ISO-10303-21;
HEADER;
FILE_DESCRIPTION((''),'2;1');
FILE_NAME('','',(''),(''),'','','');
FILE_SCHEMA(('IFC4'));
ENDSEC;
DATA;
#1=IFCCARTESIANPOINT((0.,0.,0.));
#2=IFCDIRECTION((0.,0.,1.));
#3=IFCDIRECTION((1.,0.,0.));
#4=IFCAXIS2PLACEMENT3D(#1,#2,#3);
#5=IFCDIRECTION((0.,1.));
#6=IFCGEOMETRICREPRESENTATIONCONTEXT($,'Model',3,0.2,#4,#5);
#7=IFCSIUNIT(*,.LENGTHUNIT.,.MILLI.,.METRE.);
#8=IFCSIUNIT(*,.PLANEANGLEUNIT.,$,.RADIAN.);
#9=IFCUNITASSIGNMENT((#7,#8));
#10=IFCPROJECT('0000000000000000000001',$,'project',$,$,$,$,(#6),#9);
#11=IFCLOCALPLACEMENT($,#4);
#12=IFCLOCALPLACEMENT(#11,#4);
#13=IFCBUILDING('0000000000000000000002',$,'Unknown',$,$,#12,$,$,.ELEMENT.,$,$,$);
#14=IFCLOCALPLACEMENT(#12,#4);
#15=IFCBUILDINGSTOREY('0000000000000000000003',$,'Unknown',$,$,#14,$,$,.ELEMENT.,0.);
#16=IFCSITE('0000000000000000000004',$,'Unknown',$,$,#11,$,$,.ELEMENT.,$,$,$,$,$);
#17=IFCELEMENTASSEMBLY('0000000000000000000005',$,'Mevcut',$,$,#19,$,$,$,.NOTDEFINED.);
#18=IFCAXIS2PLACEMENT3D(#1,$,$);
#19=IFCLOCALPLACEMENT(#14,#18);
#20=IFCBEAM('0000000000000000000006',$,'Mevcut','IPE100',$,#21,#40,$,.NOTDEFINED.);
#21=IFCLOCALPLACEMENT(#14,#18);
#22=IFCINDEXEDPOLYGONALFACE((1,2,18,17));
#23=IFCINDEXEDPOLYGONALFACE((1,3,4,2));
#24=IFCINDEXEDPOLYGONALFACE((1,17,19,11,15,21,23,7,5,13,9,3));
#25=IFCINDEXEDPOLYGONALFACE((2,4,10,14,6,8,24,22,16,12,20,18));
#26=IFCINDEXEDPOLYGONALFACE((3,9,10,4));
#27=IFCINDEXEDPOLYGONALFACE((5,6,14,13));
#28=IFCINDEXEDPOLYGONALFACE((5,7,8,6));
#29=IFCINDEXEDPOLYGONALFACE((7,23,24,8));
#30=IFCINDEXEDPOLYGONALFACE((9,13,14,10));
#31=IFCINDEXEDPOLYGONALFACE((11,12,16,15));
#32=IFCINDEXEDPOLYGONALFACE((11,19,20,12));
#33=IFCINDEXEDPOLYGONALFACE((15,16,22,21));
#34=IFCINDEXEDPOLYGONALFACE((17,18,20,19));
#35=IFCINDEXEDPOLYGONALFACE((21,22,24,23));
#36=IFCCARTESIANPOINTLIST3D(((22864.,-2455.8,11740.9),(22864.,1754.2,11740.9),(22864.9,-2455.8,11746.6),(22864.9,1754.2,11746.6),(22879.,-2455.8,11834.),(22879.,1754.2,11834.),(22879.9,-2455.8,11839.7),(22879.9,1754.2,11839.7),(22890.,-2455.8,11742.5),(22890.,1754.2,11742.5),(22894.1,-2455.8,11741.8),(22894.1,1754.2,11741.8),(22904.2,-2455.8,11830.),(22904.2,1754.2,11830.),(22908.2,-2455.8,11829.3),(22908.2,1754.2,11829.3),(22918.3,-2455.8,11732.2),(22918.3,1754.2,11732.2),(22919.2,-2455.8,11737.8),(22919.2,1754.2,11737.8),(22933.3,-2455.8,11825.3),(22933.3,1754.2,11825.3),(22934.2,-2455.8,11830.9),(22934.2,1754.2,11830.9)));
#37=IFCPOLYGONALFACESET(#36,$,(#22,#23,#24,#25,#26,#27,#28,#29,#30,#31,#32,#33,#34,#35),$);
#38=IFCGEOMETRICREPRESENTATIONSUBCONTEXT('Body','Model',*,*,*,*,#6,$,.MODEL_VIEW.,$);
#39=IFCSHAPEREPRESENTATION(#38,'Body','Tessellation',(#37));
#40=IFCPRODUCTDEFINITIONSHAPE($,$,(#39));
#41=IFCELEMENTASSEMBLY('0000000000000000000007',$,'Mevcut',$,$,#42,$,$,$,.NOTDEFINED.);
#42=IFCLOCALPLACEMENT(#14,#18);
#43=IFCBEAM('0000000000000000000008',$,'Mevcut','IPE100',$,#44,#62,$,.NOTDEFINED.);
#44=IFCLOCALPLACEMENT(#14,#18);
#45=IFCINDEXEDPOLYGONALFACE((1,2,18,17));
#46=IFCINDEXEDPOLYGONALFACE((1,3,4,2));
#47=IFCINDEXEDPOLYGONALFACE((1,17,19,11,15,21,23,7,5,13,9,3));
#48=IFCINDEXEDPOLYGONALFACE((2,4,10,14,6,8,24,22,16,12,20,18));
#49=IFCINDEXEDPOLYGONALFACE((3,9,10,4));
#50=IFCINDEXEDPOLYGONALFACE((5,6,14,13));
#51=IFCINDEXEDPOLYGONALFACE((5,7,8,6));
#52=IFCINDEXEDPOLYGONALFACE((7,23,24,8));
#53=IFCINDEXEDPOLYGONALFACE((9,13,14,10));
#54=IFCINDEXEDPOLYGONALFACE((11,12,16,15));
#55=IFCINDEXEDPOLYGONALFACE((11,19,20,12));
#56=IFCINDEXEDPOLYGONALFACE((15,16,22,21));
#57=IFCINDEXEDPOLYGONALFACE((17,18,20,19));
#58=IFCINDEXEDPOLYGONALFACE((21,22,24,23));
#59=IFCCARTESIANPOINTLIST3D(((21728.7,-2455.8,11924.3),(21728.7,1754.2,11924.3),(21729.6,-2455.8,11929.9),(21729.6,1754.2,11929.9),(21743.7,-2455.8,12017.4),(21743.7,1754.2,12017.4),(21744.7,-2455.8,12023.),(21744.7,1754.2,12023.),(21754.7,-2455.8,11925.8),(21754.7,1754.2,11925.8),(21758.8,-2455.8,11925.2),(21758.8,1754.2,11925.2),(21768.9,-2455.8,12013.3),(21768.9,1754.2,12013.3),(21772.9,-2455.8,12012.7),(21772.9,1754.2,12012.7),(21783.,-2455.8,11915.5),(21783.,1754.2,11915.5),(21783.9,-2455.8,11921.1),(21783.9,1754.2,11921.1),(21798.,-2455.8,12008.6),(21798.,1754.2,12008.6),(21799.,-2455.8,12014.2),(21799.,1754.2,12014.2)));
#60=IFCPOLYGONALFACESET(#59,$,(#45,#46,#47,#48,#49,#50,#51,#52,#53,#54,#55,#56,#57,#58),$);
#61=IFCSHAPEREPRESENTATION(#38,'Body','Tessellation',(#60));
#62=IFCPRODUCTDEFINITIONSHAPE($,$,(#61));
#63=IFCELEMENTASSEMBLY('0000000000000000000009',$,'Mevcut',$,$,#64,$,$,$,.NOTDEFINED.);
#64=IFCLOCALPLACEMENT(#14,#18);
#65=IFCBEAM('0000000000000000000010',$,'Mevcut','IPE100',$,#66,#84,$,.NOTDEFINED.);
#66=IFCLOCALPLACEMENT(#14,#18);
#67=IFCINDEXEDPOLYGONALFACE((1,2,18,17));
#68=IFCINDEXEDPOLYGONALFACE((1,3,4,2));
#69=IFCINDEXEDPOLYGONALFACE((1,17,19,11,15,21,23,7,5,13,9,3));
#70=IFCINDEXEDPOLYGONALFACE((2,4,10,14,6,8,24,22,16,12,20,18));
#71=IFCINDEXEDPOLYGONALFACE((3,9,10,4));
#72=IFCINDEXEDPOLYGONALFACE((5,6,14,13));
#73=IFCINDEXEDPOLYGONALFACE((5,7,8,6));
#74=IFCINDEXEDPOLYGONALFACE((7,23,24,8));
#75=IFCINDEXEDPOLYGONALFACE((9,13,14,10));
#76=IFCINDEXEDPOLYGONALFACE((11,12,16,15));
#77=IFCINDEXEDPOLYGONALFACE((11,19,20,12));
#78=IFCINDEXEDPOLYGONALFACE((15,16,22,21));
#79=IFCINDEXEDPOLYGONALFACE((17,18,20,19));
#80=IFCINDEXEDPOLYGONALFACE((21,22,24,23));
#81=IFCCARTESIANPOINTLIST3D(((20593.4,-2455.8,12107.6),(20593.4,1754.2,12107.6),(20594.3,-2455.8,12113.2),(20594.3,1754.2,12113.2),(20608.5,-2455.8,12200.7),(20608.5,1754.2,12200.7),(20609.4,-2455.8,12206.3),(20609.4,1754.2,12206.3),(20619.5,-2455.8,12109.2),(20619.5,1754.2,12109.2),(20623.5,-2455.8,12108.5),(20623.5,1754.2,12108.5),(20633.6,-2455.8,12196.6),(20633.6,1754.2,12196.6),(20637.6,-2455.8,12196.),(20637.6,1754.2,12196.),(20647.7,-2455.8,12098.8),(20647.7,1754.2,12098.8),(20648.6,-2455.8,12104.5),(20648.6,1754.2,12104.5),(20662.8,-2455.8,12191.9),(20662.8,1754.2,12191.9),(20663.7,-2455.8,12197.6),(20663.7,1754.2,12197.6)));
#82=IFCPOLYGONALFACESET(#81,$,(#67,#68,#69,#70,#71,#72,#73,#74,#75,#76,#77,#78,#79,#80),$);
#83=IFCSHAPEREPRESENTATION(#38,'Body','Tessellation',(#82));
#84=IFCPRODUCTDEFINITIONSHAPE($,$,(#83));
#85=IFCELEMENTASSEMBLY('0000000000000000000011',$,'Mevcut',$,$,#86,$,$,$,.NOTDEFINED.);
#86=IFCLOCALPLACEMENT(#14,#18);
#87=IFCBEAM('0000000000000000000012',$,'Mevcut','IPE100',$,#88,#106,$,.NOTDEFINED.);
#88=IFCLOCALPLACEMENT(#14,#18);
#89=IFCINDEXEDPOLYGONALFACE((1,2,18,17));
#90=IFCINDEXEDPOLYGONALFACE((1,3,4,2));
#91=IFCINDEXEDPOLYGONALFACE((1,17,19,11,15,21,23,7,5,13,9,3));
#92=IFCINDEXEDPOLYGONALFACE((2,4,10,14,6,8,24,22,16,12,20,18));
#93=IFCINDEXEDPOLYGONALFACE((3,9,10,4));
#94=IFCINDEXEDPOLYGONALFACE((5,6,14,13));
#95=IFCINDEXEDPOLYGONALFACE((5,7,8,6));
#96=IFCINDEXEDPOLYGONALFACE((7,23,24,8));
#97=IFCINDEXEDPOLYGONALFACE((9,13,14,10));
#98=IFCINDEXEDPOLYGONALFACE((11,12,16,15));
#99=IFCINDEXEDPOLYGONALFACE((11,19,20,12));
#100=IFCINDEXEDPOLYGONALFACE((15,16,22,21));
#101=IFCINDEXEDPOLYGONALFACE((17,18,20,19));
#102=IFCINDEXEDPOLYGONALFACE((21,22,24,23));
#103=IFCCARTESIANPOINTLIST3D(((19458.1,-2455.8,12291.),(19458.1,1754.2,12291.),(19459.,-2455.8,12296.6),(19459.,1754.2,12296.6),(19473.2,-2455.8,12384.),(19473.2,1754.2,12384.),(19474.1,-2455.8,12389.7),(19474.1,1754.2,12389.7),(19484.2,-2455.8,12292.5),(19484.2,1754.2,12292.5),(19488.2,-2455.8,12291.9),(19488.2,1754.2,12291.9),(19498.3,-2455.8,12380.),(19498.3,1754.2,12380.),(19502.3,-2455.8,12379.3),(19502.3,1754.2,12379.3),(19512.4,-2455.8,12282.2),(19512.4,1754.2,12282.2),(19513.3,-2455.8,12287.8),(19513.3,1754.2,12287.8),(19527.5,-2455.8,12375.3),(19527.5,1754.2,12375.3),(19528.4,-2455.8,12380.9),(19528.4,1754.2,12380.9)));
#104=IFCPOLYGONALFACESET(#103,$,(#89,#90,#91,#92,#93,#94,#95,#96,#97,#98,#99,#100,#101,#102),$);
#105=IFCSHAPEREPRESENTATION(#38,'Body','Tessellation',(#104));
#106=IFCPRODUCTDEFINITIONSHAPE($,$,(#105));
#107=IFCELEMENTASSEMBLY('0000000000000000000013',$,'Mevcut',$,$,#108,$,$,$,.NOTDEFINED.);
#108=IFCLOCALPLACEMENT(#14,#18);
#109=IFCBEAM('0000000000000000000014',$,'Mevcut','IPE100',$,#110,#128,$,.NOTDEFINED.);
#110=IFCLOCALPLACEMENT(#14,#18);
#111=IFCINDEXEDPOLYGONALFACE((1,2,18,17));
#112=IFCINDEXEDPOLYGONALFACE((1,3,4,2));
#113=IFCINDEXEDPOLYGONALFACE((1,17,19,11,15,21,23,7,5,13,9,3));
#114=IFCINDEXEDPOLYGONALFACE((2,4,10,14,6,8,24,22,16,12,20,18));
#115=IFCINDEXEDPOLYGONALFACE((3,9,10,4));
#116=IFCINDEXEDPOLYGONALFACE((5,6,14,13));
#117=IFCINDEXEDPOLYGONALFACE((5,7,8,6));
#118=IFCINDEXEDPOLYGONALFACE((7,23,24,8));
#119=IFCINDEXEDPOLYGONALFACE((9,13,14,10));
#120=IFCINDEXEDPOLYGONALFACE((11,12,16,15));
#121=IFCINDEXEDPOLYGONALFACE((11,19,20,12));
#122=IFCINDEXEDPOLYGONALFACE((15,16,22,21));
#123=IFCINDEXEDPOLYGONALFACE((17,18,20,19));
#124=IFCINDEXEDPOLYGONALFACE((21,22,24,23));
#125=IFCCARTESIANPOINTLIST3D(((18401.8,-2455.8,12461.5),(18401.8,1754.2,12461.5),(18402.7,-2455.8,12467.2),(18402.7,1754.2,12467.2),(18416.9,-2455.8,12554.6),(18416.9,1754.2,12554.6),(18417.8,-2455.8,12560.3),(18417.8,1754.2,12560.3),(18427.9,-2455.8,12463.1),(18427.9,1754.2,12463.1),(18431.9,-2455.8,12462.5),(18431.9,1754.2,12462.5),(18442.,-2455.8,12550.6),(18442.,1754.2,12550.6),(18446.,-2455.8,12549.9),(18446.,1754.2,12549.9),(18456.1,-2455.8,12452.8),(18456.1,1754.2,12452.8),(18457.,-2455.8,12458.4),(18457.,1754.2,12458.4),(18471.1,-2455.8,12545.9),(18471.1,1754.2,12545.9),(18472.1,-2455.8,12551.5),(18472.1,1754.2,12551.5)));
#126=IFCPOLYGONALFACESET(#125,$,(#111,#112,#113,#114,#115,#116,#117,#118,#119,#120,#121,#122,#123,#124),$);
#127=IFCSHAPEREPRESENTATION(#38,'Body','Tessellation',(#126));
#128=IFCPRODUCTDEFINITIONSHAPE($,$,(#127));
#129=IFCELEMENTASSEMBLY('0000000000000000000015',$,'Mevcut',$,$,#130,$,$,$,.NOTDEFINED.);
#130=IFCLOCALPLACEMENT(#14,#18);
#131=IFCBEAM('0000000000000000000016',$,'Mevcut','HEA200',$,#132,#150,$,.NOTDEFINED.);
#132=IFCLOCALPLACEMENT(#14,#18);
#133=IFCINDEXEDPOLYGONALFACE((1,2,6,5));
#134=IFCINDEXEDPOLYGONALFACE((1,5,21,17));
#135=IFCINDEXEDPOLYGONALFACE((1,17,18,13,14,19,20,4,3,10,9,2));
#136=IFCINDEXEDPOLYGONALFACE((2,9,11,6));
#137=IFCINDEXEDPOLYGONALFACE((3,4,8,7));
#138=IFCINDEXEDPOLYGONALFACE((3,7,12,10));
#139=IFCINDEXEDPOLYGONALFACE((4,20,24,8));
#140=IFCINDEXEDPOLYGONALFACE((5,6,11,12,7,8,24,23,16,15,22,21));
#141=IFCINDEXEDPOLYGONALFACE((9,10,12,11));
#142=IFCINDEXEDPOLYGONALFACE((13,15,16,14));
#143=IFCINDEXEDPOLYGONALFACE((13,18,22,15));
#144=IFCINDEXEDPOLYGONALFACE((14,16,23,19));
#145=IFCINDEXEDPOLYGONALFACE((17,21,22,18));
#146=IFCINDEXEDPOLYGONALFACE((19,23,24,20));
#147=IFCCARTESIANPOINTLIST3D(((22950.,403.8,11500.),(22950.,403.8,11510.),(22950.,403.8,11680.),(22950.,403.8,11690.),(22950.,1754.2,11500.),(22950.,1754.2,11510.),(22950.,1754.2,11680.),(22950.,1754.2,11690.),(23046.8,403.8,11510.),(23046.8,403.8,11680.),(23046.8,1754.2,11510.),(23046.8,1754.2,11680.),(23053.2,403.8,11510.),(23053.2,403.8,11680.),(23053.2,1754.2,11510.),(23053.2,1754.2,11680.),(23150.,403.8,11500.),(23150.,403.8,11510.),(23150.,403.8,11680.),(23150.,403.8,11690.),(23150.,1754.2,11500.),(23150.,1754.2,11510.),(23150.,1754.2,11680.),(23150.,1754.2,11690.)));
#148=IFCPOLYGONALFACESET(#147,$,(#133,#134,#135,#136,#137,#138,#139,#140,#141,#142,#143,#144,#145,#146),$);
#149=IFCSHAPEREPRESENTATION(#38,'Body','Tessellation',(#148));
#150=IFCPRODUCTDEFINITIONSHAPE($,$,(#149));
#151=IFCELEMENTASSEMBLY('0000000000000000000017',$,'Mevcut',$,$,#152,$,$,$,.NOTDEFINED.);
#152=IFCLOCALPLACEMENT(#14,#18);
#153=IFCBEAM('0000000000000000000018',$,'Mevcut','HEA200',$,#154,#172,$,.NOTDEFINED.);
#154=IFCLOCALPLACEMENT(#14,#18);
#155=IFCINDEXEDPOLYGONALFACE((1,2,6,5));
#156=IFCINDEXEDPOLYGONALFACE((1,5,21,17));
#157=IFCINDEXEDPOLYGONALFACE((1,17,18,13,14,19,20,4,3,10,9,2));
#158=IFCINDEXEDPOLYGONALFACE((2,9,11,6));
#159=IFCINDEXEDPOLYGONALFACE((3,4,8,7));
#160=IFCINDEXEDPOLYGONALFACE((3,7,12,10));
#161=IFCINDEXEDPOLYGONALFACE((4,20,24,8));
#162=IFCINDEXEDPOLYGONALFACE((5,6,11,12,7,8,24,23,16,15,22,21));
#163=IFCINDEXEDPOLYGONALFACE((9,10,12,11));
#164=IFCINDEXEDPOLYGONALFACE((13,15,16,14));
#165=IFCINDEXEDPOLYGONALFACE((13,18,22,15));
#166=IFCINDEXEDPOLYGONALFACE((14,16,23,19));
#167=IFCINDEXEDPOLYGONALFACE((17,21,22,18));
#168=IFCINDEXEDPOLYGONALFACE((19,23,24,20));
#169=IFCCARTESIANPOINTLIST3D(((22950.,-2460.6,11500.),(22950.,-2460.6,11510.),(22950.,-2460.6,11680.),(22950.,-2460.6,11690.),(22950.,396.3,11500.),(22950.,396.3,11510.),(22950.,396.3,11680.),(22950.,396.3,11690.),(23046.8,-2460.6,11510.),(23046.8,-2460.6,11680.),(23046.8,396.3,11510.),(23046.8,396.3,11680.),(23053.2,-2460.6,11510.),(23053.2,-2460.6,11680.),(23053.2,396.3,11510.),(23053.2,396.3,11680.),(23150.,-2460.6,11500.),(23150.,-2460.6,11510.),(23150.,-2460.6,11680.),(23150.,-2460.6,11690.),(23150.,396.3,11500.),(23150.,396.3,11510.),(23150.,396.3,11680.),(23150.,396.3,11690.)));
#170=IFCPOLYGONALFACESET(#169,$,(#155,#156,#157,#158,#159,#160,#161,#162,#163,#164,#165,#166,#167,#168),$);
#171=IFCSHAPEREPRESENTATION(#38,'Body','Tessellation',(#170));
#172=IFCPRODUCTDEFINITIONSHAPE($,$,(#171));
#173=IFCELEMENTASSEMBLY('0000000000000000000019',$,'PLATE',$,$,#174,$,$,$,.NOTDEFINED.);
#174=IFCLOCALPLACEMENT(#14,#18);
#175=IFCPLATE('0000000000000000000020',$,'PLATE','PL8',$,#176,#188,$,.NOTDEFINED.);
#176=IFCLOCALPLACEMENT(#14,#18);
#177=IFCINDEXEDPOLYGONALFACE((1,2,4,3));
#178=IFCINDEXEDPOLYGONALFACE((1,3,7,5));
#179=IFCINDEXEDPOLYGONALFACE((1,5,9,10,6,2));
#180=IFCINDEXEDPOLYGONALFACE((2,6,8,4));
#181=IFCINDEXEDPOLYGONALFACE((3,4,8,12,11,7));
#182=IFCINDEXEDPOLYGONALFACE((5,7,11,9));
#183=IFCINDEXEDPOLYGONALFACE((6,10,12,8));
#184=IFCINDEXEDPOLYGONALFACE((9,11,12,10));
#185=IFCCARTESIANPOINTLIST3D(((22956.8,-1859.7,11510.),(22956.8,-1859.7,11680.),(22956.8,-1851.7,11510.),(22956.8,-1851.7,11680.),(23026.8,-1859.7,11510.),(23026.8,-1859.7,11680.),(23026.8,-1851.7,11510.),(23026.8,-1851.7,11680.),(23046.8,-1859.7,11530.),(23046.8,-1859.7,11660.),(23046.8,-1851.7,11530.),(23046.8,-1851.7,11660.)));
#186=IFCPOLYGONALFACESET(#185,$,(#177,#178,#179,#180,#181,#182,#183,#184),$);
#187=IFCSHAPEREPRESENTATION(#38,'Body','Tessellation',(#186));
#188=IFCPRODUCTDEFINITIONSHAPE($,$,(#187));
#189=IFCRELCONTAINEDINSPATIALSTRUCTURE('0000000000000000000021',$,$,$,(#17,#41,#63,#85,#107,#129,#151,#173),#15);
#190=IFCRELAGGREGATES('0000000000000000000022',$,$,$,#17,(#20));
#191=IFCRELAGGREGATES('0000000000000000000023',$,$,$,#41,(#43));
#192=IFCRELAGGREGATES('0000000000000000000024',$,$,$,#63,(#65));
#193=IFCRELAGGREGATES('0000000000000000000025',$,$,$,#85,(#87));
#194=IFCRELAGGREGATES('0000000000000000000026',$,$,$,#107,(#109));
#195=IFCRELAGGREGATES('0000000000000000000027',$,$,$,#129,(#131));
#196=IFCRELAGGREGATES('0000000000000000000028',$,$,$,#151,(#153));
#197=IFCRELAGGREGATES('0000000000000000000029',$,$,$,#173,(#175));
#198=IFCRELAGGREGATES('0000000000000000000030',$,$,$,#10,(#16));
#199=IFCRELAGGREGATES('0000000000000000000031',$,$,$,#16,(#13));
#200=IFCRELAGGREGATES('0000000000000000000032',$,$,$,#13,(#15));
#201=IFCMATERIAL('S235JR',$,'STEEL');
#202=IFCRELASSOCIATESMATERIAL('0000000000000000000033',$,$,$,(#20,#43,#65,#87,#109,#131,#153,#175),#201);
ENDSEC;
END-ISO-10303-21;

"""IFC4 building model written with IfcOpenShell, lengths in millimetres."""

from ifc_helpers import new_model, si_unit, direction, frame, origin_with_axes, place, context, subcontext, project, spatial, line, indexed_curve, outline, extrude, material, element, aggregate, save


model = new_model("IFC4")

# Units and contexts
model_context = context("Model", 3, precision=0.2, world=origin_with_axes(), true_north=direction((0.0, 1.0)))
body_context = subcontext(model_context, "Body", "Model", "MODEL_VIEW")
ifc_project = project(units=[si_unit("LENGTHUNIT", "METRE", prefix="MILLI"), si_unit("PLANEANGLEUNIT", "RADIAN")], contexts=[model_context])

# Site, building, storey
site_placement = place(None, origin_with_axes())
site = spatial("IfcSite", under=ifc_project, at=site_placement, Name="Unknown", CompositionType="ELEMENT")
building_placement = place(site_placement, origin_with_axes())
building = spatial("IfcBuilding", under=site, at=building_placement, Name="Unknown", CompositionType="ELEMENT")
storey_placement = place(building_placement, origin_with_axes())
storey = spatial("IfcBuildingStorey", under=building, at=storey_placement, Name="Unknown", CompositionType="ELEMENT", Elevation=0.0)

# Element assemblies, beams
assembly_1_placement = place(storey_placement, frame((22899.1, 1754.2, 11785.9), z_axis=(0.98722, 0.0, -0.159364), x_axis=(0.0, -1.0, 0.0)))
assembly_1 = element("IfcElementAssembly", 1, at=assembly_1_placement, inside=storey, Name="Mevcut", PredefinedType="NOTDEFINED")
ifc_material = material(Name="S235JR", Category="STEEL")
beam_1_placement = place(assembly_1_placement, origin_with_axes())
beam_1 = element("IfcBeam", 2, at=beam_1_placement, material=ifc_material, Name="Mevcut", Description="IPE100", PredefinedType="NOTDEFINED", context=body_context, shape_type="SolidModel", body=[
    extrude(outline(indexed_curve([(-27.5, -50.0), (27.5, -50.0), (27.5, -44.3), (2.0, -44.3), (2.0, 44.3), (27.5, 44.3), (27.5, 50.0), (-27.5, 50.0), (-27.5, 44.3), (-2.0, 44.3), (-2.0, -44.3), (-27.5, -44.3)], segments=[line(1, 2, 3, 4, 5, 6, 7, 8, 9, 10, 11, 12, 1)])), frame((0.0, 0.0, 0.0), z_axis=(-1.0, 0.0, 0.0), x_axis=(0.0, 0.0, 1.0)), (0.0, 0.0, -1.0), 4210.0),
])
aggregate(assembly_1, [beam_1])
assembly_2_placement = place(storey_placement, frame((21763.8, 1754.2, 11969.2), z_axis=(0.98721, 0.0, -0.159427), x_axis=(0.0, -1.0, 0.0)))
assembly_2 = element("IfcElementAssembly", 3, at=assembly_2_placement, inside=storey, Name="Mevcut", PredefinedType="NOTDEFINED")
beam_2_placement = place(assembly_2_placement, origin_with_axes())
beam_2 = element("IfcBeam", 4, at=beam_2_placement, material=ifc_material, Name="Mevcut", Description="IPE100", PredefinedType="NOTDEFINED", context=body_context, shape_type="SolidModel", body=[
    extrude(outline(indexed_curve([(-27.5, -50.0), (27.5, -50.0), (27.5, -44.3), (2.0, -44.3), (2.0, 44.3), (27.5, 44.3), (27.5, 50.0), (-27.5, 50.0), (-27.5, 44.3), (-2.0, 44.3), (-2.0, -44.3), (-27.5, -44.3)], segments=[line(1, 2, 3, 4, 5, 6, 7, 8, 9, 10, 11, 12, 1)])), frame((0.0, 0.0, 0.0), z_axis=(-1.0, 0.0, 0.0), x_axis=(0.0, 0.0, 1.0)), (0.0, 0.0, -1.0), 4210.0),
])
aggregate(assembly_2, [beam_2])
assembly_3_placement = place(storey_placement, frame((20628.5, 1754.2, 12152.6), z_axis=(0.98721, 0.0, -0.159427), x_axis=(0.0, -1.0, 0.0)))
assembly_3 = element("IfcElementAssembly", 5, at=assembly_3_placement, inside=storey, Name="Mevcut", PredefinedType="NOTDEFINED")
beam_3_placement = place(assembly_3_placement, origin_with_axes())
beam_3 = element("IfcBeam", 6, at=beam_3_placement, material=ifc_material, Name="Mevcut", Description="IPE100", PredefinedType="NOTDEFINED", context=body_context, shape_type="SolidModel", body=[
    extrude(outline(indexed_curve([(-27.5, -50.0), (27.5, -50.0), (27.5, -44.3), (2.0, -44.3), (2.0, 44.3), (27.5, 44.3), (27.5, 50.0), (-27.5, 50.0), (-27.5, 44.3), (-2.0, 44.3), (-2.0, -44.3), (-27.5, -44.3)], segments=[line(1, 2, 3, 4, 5, 6, 7, 8, 9, 10, 11, 12, 1)])), frame((0.0, 0.0, 0.0), z_axis=(-1.0, 0.0, 0.0), x_axis=(0.0, 0.0, 1.0)), (0.0, 0.0, -1.0), 4210.0),
])
aggregate(assembly_3, [beam_3])
assembly_4_placement = place(storey_placement, frame((19493.3, 1754.2, 12335.9), z_axis=(0.98721, 0.0, -0.159427), x_axis=(0.0, -1.0, 0.0)))
assembly_4 = element("IfcElementAssembly", 7, at=assembly_4_placement, inside=storey, Name="Mevcut", PredefinedType="NOTDEFINED")
beam_4_placement = place(assembly_4_placement, origin_with_axes())
beam_4 = element("IfcBeam", 8, at=beam_4_placement, material=ifc_material, Name="Mevcut", Description="IPE100", PredefinedType="NOTDEFINED", context=body_context, shape_type="SolidModel", body=[
    extrude(outline(indexed_curve([(-27.5, -50.0), (27.5, -50.0), (27.5, -44.3), (2.0, -44.3), (2.0, 44.3), (27.5, 44.3), (27.5, 50.0), (-27.5, 50.0), (-27.5, 44.3), (-2.0, 44.3), (-2.0, -44.3), (-27.5, -44.3)], segments=[line(1, 2, 3, 4, 5, 6, 7, 8, 9, 10, 11, 12, 1)])), frame((0.0, 0.0, 0.0), z_axis=(-1.0, 0.0, 0.0), x_axis=(0.0, 0.0, 1.0)), (0.0, 0.0, -1.0), 4210.0),
])
aggregate(assembly_4, [beam_4])
assembly_5_placement = place(storey_placement, frame((18436.9, 1754.2, 12506.5), z_axis=(0.98721, 0.0, -0.159427), x_axis=(0.0, -1.0, 0.0)))
assembly_5 = element("IfcElementAssembly", 9, at=assembly_5_placement, inside=storey, Name="Mevcut", PredefinedType="NOTDEFINED")
beam_5_placement = place(assembly_5_placement, origin_with_axes())
beam_5 = element("IfcBeam", 10, at=beam_5_placement, material=ifc_material, Name="Mevcut", Description="IPE100", PredefinedType="NOTDEFINED", context=body_context, shape_type="SolidModel", body=[
    extrude(outline(indexed_curve([(-27.5, -50.0), (27.5, -50.0), (27.5, -44.3), (2.0, -44.3), (2.0, 44.3), (27.5, 44.3), (27.5, 50.0), (-27.5, 50.0), (-27.5, 44.3), (-2.0, 44.3), (-2.0, -44.3), (-27.5, -44.3)], segments=[line(1, 2, 3, 4, 5, 6, 7, 8, 9, 10, 11, 12, 1)])), frame((0.0, 0.0, 0.0), z_axis=(-1.0, 0.0, 0.0), x_axis=(0.0, 0.0, 1.0)), (0.0, 0.0, -1.0), 4210.0),
])
aggregate(assembly_5, [beam_5])
assembly_6_placement = place(storey_placement, frame((23050.0, 1754.2, 11595.0), z_axis=(-1.0, 0.0, 0.0), x_axis=(0.0, -1.0, 0.0)))
assembly_6 = element("IfcElementAssembly", 11, at=assembly_6_placement, inside=storey, Name="Mevcut", PredefinedType="NOTDEFINED")
beam_6_placement = place(assembly_6_placement, origin_with_axes())
beam_6 = element("IfcBeam", 12, at=beam_6_placement, material=ifc_material, Name="Mevcut", Description="HEA200", PredefinedType="NOTDEFINED", context=body_context, shape_type="SolidModel", body=[
    extrude(outline(indexed_curve([(-100.0, -95.0), (100.0, -95.0), (100.0, -85.0), (3.2, -85.0), (3.2, 85.0), (100.0, 85.0), (100.0, 95.0), (-100.0, 95.0), (-100.0, 85.0), (-3.2, 85.0), (-3.2, -85.0), (-100.0, -85.0)], segments=[line(1, 2, 3, 4, 5, 6, 7, 8, 9, 10, 11, 12, 1)])), frame((0.0, 0.0, 0.0), z_axis=(-1.0, 0.0, 0.0), x_axis=(0.0, 0.0, 1.0)), (0.0, 0.0, -1.0), 1350.4),
])
aggregate(assembly_6, [beam_6])
assembly_7_placement = place(storey_placement, frame((23050.0, 396.3, 11595.0), z_axis=(-1.0, 0.0, 0.0), x_axis=(0.0, -1.0, 0.0)))
assembly_7 = element("IfcElementAssembly", 13, at=assembly_7_placement, inside=storey, Name="Mevcut", PredefinedType="NOTDEFINED")
beam_7_placement = place(assembly_7_placement, origin_with_axes())
beam_7 = element("IfcBeam", 14, at=beam_7_placement, material=ifc_material, Name="Mevcut", Description="HEA200", PredefinedType="NOTDEFINED", context=body_context, shape_type="SolidModel", body=[
    extrude(outline(indexed_curve([(-100.0, -95.0), (100.0, -95.0), (100.0, -85.0), (3.2, -85.0), (3.2, 85.0), (100.0, 85.0), (100.0, 95.0), (-100.0, 95.0), (-100.0, 85.0), (-3.2, 85.0), (-3.2, -85.0), (-100.0, -85.0)], segments=[line(1, 2, 3, 4, 5, 6, 7, 8, 9, 10, 11, 12, 1)])), frame((0.0, 0.0, 0.0), z_axis=(-1.0, 0.0, 0.0), x_axis=(0.0, 0.0, 1.0)), (0.0, 0.0, -1.0), 2856.9),
])
aggregate(assembly_7, [beam_7])

# Element assembly, plate
assembly_8_placement = place(storey_placement, frame((23046.8, -1855.7, 11510.0), z_axis=(0.0, 1.0, 0.0), x_axis=(-1.0, 0.0, 0.0)))
assembly_8 = element("IfcElementAssembly", 15, at=assembly_8_placement, inside=storey, Name="PLATE", PredefinedType="NOTDEFINED")
plate_1_placement = place(assembly_8_placement, origin_with_axes())
plate_1 = element("IfcPlate", 16, at=plate_1_placement, material=ifc_material, Name="PLATE", Description="PL8", PredefinedType="NOTDEFINED", context=body_context, shape_type="SolidModel", body=[
    extrude(outline(indexed_curve([(0.0, 20.0), (20.0, 0.0), (90.0, 0.0), (90.0, 170.0), (20.0, 170.0), (0.0, 150.0)], segments=[line(1, 2, 3, 4, 5, 6, 1)])), frame((0.0, 0.0, 4.0), z_axis=(0.0, 0.0, 1.0), x_axis=(1.0, 0.0, 0.0)), (0.0, 0.0, -1.0), 8.0),
])
aggregate(assembly_8, [plate_1])

save(model, "model.ifc")
